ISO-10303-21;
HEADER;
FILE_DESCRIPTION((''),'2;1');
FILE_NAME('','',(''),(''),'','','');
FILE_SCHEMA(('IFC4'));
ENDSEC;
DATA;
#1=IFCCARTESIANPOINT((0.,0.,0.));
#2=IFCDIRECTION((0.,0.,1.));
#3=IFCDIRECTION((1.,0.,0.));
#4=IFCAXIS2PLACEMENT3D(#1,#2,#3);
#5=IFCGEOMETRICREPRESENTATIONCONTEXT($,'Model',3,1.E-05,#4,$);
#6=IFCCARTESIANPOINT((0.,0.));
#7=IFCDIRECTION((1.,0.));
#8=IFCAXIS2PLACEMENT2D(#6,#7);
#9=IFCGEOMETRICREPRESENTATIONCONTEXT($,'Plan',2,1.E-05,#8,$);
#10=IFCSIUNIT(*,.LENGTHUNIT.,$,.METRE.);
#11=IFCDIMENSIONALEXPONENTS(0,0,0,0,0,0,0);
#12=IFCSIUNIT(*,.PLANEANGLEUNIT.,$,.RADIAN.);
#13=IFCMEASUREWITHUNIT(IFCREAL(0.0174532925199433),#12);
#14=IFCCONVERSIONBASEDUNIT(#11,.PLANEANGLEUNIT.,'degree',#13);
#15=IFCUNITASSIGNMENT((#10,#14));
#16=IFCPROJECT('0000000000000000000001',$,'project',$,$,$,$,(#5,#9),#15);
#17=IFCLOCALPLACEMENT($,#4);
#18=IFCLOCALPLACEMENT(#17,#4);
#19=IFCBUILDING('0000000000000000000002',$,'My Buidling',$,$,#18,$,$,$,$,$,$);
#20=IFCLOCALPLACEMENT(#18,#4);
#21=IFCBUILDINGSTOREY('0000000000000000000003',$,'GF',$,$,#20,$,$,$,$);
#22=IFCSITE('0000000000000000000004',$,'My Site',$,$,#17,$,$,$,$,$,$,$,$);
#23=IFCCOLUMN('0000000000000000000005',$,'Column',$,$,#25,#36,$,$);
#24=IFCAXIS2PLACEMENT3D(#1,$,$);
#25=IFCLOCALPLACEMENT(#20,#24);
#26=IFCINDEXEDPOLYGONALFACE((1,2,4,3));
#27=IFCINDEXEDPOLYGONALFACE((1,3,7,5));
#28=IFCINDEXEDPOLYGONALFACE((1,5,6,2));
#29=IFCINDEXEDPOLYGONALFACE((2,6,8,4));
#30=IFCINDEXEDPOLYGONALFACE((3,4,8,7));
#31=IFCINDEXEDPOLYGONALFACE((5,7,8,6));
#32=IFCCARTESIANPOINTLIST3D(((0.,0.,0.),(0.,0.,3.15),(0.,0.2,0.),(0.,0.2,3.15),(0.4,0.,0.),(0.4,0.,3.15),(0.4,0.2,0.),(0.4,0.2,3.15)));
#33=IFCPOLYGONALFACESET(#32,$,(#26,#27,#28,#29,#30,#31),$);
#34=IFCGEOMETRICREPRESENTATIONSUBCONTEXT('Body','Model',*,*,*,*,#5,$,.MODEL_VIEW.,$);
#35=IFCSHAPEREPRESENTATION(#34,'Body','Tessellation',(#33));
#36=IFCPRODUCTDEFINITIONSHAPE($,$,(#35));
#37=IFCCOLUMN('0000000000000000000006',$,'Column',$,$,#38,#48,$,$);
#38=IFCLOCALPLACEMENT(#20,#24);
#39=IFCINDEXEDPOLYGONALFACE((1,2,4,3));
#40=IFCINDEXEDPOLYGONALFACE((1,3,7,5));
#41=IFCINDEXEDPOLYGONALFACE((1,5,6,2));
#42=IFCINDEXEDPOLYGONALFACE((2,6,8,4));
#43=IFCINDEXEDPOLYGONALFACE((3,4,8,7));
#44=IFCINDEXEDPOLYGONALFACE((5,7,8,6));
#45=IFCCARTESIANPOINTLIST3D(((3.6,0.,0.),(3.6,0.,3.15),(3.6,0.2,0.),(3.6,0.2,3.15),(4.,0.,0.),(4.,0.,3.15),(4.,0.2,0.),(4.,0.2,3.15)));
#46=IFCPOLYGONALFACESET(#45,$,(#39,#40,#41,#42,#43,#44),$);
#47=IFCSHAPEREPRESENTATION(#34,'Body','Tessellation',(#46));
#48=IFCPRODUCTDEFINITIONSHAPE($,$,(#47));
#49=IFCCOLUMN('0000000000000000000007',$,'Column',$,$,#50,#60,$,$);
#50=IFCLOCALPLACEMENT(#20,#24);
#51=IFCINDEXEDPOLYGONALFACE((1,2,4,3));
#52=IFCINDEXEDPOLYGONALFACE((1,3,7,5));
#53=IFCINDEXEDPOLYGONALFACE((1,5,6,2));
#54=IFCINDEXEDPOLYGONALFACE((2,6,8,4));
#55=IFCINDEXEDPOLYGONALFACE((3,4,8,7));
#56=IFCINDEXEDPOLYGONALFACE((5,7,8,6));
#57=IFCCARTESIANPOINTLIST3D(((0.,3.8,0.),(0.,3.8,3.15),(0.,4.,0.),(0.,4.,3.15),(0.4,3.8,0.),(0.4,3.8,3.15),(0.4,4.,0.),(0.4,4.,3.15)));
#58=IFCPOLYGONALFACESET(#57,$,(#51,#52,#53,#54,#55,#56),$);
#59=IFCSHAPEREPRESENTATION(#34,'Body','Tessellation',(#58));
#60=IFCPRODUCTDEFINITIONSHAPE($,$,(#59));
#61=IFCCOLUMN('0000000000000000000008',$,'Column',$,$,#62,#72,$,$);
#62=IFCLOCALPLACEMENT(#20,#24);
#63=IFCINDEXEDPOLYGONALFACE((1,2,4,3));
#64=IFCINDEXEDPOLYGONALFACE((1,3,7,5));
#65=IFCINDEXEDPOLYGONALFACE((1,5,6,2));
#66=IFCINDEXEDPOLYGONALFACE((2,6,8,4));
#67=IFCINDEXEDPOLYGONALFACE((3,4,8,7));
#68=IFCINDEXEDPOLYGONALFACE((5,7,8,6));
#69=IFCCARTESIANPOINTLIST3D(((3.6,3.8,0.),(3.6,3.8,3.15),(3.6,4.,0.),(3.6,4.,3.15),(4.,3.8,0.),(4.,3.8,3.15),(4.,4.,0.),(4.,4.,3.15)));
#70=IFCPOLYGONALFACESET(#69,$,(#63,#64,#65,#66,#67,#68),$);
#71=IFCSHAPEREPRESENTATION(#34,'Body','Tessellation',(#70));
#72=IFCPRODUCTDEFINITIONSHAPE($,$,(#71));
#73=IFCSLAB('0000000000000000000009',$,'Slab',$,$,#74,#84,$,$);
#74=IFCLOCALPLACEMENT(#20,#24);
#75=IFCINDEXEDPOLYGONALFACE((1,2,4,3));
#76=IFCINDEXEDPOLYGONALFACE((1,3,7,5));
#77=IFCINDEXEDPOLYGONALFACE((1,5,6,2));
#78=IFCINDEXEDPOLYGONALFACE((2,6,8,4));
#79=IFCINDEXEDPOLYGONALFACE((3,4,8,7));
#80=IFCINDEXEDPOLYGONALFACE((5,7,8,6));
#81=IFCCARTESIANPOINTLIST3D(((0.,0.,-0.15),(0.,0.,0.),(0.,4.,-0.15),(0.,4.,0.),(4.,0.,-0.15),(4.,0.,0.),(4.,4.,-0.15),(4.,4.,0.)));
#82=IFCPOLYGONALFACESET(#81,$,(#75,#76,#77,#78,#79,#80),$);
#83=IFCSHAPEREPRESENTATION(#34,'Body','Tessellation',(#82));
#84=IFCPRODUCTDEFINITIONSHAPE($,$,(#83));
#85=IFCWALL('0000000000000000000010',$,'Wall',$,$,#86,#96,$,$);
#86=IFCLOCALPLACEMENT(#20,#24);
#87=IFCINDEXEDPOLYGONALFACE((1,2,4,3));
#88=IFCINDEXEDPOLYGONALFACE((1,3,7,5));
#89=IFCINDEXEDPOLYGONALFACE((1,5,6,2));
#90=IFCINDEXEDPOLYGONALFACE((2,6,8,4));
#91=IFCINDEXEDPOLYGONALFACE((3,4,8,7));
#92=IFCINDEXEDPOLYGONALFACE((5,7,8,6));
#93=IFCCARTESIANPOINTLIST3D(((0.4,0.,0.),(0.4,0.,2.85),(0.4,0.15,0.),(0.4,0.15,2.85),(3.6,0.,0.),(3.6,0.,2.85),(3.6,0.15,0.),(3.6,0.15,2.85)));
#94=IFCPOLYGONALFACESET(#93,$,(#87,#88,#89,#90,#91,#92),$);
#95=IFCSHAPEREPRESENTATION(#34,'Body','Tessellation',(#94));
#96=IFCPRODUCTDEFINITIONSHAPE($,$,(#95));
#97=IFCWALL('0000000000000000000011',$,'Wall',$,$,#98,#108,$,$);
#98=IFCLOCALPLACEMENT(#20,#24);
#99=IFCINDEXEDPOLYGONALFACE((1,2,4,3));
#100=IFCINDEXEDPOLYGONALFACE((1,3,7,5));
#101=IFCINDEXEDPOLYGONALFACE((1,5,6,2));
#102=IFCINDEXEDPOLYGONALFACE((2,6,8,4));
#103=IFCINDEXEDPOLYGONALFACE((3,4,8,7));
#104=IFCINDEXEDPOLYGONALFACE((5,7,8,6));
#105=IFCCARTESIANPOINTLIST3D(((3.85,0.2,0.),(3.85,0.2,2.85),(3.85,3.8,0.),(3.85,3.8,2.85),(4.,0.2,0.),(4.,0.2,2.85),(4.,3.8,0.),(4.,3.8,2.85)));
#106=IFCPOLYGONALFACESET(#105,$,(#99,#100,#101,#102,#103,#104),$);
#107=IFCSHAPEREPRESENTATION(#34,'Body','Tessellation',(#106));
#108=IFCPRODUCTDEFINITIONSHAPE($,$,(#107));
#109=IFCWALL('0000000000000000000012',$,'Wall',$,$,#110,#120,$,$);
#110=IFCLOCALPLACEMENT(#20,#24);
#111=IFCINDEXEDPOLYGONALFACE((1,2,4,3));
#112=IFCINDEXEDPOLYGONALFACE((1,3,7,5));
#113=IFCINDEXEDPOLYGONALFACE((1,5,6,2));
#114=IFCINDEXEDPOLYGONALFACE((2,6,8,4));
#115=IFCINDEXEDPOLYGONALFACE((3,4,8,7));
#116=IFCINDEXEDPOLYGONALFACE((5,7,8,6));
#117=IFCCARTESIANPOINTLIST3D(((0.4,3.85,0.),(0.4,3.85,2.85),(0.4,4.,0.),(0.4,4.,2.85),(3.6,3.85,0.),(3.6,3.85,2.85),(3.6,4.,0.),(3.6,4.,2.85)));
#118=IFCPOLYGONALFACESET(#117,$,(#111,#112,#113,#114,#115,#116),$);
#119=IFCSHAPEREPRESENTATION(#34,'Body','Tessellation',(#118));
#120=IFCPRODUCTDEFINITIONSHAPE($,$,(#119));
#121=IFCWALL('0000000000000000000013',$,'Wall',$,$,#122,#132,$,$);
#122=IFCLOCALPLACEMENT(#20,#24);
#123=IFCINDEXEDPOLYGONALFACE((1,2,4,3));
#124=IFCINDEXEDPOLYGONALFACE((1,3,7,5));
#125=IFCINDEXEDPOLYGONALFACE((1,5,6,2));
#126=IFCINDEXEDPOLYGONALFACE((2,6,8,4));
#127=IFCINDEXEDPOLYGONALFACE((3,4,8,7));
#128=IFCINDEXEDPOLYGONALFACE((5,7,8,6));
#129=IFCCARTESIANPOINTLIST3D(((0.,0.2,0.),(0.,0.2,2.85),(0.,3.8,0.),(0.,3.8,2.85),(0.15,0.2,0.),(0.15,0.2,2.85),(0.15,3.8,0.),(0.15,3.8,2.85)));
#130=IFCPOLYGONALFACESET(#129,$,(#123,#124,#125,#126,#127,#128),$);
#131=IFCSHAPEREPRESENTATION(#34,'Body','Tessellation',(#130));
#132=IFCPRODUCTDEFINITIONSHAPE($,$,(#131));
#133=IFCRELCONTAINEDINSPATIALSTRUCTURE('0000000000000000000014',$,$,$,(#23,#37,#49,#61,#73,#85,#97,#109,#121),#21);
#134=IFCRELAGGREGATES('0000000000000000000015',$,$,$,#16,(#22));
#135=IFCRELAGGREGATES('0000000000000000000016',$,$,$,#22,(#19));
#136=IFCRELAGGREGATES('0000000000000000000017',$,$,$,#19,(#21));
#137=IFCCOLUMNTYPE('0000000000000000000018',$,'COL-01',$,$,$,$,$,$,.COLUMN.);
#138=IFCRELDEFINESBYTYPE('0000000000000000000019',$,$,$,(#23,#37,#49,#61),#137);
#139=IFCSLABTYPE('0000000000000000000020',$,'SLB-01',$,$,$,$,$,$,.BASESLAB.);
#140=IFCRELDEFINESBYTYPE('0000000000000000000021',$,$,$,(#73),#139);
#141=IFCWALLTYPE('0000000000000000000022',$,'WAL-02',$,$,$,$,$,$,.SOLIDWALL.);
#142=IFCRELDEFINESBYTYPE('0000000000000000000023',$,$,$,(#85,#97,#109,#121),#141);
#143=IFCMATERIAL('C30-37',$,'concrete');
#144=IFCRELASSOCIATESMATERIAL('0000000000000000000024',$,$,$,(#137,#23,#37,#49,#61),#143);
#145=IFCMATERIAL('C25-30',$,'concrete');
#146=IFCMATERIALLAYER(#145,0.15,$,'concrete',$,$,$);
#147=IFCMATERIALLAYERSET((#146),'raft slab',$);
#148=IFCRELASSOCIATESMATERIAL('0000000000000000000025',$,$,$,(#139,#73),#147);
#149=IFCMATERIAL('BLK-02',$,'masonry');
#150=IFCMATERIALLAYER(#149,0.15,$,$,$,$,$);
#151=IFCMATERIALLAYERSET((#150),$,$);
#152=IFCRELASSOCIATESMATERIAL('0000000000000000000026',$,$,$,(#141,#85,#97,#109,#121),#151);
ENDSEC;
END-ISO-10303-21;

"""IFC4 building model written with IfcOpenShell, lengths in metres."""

from ifc_helpers import new_model, entity, si_unit, converted_unit, frame, origin_with_axes, origin_2d_with_axis, place, context, subcontext, project, spatial, line, indexed_curve, rectangle, outline, extrude, material, layer, layer_set, layer_usage, material_profile, profile_set, profile_usage, type_object, element, save


model = new_model("IFC4")

# Units and contexts
model_context = context("Model", 3, precision=1e-05, world=origin_with_axes())
plan_context = context("Plan", 2, precision=1e-05, world=origin_2d_with_axis())
body_context = subcontext(model_context, "Body", "Model", "MODEL_VIEW")
ifc_project = project(units=[si_unit("LENGTHUNIT", "METRE"), converted_unit("PLANEANGLEUNIT", "degree", entity("IfcReal", 0.0174532925199433), si_unit("PLANEANGLEUNIT", "RADIAN"), dimensions=[0, 0, 0, 0, 0, 0, 0])], contexts=[model_context, plan_context])

# Site, building, storey
site_placement = place(None, origin_with_axes())
site = spatial("IfcSite", under=ifc_project, at=site_placement, Name="My Site")
building_placement = place(site_placement, origin_with_axes())
building = spatial("IfcBuilding", under=site, at=building_placement, Name="My Buidling")
storey_placement = place(building_placement, origin_with_axes())
storey = spatial("IfcBuildingStorey", under=building, at=storey_placement, Name="GF")

# Columns
ifc_material_1 = material(Name="C30-37", Category="concrete")
ifc_material_profile = material_profile(ifc_material_1, rectangle(XDim=0.2, YDim=0.4))
ifc_profile_set = profile_set([ifc_material_profile])
ifc_profile_usage_1 = profile_usage(ifc_profile_set, cardinal=1)
column_type = type_object("IfcColumnType", Name="COL-01", PredefinedType="COLUMN", material=ifc_profile_set)
column_1_placement = place(storey_placement, frame((0.0, 0.0, 0.0), z_axis=(0.0, 0.0, 1.0), x_axis=(0.0, -1.0, 0.0)))
element("IfcColumn", 1, at=column_1_placement, inside=storey, type_object=column_type, material=ifc_profile_usage_1, Name="Column", context=body_context, shape_type="SweptSolid", body=[
    extrude(rectangle(XDim=0.2, YDim=0.4), frame((-0.1, 0.2, 0.0), z_axis=(0.0, 0.0, 1.0), x_axis=(1.0, 0.0, 0.0)), (0.0, 0.0, 1.0), 3.15),
])
ifc_profile_usage_2 = profile_usage(ifc_profile_set, cardinal=1)
column_2_placement = place(storey_placement, frame((3.6, 0.0, 0.0), z_axis=(0.0, 0.0, 1.0), x_axis=(0.0, -1.0, 0.0)))
element("IfcColumn", 2, at=column_2_placement, inside=storey, type_object=column_type, material=ifc_profile_usage_2, Name="Column", context=body_context, shape_type="SweptSolid", body=[
    extrude(rectangle(XDim=0.2, YDim=0.4), frame((-0.1, 0.2, 0.0), z_axis=(0.0, 0.0, 1.0), x_axis=(1.0, 0.0, 0.0)), (0.0, 0.0, 1.0), 3.15),
])
ifc_profile_usage_3 = profile_usage(ifc_profile_set, cardinal=1)
column_3_placement = place(storey_placement, frame((0.0, 3.8, 0.0), z_axis=(0.0, 0.0, 1.0), x_axis=(0.0, -1.0, 0.0)))
element("IfcColumn", 3, at=column_3_placement, inside=storey, type_object=column_type, material=ifc_profile_usage_3, Name="Column", context=body_context, shape_type="SweptSolid", body=[
    extrude(rectangle(XDim=0.2, YDim=0.4), frame((-0.1, 0.2, 0.0), z_axis=(0.0, 0.0, 1.0), x_axis=(1.0, 0.0, 0.0)), (0.0, 0.0, 1.0), 3.15),
])
ifc_profile_usage_4 = profile_usage(ifc_profile_set, cardinal=1)
column_4_placement = place(storey_placement, frame((3.6, 3.8, 0.0), z_axis=(0.0, 0.0, 1.0), x_axis=(0.0, -1.0, 0.0)))
element("IfcColumn", 4, at=column_4_placement, inside=storey, type_object=column_type, material=ifc_profile_usage_4, Name="Column", context=body_context, shape_type="SweptSolid", body=[
    extrude(rectangle(XDim=0.2, YDim=0.4), frame((-0.1, 0.2, 0.0), z_axis=(0.0, 0.0, 1.0), x_axis=(1.0, 0.0, 0.0)), (0.0, 0.0, 1.0), 3.15),
])

# Slab
ifc_material_2 = material(Name="C25-30", Category="concrete")
ifc_layer_1 = layer(ifc_material_2, 0.15, Name="concrete")
ifc_layer_set_1 = layer_set([ifc_layer_1], Name="raft slab")
ifc_layer_usage_1 = layer_usage(ifc_layer_set_1, "AXIS3", "POSITIVE", 0.0)
slab_type = type_object("IfcSlabType", Name="SLB-01", PredefinedType="BASESLAB", material=ifc_layer_set_1)
slab_placement = place(storey_placement, frame((0.0, 0.0, -0.15), z_axis=(0.0, 0.0, 1.0), x_axis=(1.0, 0.0, 0.0)))
element("IfcSlab", 5, at=slab_placement, inside=storey, type_object=slab_type, material=ifc_layer_usage_1, Name="Slab", context=body_context, shape_type="SweptSolid", body=[
    extrude(outline(indexed_curve([(0.0, 0.0), (4.0, 0.0), (4.0, 4.0), (0.0, 4.0)], segments=[line(4, 1), line(1, 2), line(2, 3), line(3, 4)], self_intersect=False)), None, (0.0, 0.0, 1.0), 0.15),
])

# Walls
ifc_material_3 = material(Name="BLK-02", Category="masonry")
ifc_layer_2 = layer(ifc_material_3, 0.15)
ifc_layer_set_2 = layer_set([ifc_layer_2])
ifc_layer_usage_2 = layer_usage(ifc_layer_set_2, "AXIS2", "POSITIVE", 0.0)
wall_type = type_object("IfcWallType", Name="WAL-02", PredefinedType="SOLIDWALL", material=ifc_layer_set_2)
wall_1_placement = place(storey_placement, frame((0.4, 0.0, 0.0), z_axis=(0.0, 0.0, 1.0), x_axis=(1.0, 0.0, 0.0)))
element("IfcWall", 6, at=wall_1_placement, inside=storey, type_object=wall_type, material=ifc_layer_usage_2, Name="Wall", context=body_context, shape_type="SweptSolid", body=[
    extrude(outline(indexed_curve([(0.0, 0.0), (0.0, 0.15), (3.2, 0.15), (3.2, 0.0), (0.0, 0.0)], self_intersect=False)), origin_with_axes(), (0.0, 0.0, 1.0), 2.85),
])
ifc_layer_usage_3 = layer_usage(ifc_layer_set_2, "AXIS2", "POSITIVE", 0.0)
wall_2_placement = place(storey_placement, frame((4.0, 0.2, 0.0), z_axis=(0.0, 0.0, 1.0), x_axis=(0.0, 1.0, 0.0)))
element("IfcWall", 7, at=wall_2_placement, inside=storey, type_object=wall_type, material=ifc_layer_usage_3, Name="Wall", context=body_context, shape_type="SweptSolid", body=[
    extrude(outline(indexed_curve([(0.0, 0.0), (0.0, 0.15), (3.6, 0.15), (3.6, 0.0), (0.0, 0.0)], self_intersect=False)), origin_with_axes(), (0.0, 0.0, 1.0), 2.85),
])
ifc_layer_usage_4 = layer_usage(ifc_layer_set_2, "AXIS2", "POSITIVE", 0.0)
wall_3_placement = place(storey_placement, frame((3.6, 4.0, 0.0), z_axis=(0.0, 0.0, 1.0), x_axis=(-1.0, 0.0, 0.0)))
element("IfcWall", 8, at=wall_3_placement, inside=storey, type_object=wall_type, material=ifc_layer_usage_4, Name="Wall", context=body_context, shape_type="SweptSolid", body=[
    extrude(outline(indexed_curve([(0.0, 0.0), (0.0, 0.15), (3.2, 0.15), (3.2, 0.0), (0.0, 0.0)], self_intersect=False)), origin_with_axes(), (0.0, 0.0, 1.0), 2.85),
])
ifc_layer_usage_5 = layer_usage(ifc_layer_set_2, "AXIS2", "POSITIVE", 0.0)
wall_4_placement = place(storey_placement, frame((0.0, 3.8, 0.0), z_axis=(0.0, 0.0, 1.0), x_axis=(-0.000001, -1.0, 0.0)))
element("IfcWall", 9, at=wall_4_placement, inside=storey, type_object=wall_type, material=ifc_layer_usage_5, Name="Wall", context=body_context, shape_type="SweptSolid", body=[
    extrude(outline(indexed_curve([(0.0, 0.0), (0.0, 0.15), (3.6, 0.15), (3.6, 0.0), (0.0, 0.0)], self_intersect=False)), origin_with_axes(), (0.0, 0.0, 1.0), 2.85),
])

save(model, "model.ifc")
